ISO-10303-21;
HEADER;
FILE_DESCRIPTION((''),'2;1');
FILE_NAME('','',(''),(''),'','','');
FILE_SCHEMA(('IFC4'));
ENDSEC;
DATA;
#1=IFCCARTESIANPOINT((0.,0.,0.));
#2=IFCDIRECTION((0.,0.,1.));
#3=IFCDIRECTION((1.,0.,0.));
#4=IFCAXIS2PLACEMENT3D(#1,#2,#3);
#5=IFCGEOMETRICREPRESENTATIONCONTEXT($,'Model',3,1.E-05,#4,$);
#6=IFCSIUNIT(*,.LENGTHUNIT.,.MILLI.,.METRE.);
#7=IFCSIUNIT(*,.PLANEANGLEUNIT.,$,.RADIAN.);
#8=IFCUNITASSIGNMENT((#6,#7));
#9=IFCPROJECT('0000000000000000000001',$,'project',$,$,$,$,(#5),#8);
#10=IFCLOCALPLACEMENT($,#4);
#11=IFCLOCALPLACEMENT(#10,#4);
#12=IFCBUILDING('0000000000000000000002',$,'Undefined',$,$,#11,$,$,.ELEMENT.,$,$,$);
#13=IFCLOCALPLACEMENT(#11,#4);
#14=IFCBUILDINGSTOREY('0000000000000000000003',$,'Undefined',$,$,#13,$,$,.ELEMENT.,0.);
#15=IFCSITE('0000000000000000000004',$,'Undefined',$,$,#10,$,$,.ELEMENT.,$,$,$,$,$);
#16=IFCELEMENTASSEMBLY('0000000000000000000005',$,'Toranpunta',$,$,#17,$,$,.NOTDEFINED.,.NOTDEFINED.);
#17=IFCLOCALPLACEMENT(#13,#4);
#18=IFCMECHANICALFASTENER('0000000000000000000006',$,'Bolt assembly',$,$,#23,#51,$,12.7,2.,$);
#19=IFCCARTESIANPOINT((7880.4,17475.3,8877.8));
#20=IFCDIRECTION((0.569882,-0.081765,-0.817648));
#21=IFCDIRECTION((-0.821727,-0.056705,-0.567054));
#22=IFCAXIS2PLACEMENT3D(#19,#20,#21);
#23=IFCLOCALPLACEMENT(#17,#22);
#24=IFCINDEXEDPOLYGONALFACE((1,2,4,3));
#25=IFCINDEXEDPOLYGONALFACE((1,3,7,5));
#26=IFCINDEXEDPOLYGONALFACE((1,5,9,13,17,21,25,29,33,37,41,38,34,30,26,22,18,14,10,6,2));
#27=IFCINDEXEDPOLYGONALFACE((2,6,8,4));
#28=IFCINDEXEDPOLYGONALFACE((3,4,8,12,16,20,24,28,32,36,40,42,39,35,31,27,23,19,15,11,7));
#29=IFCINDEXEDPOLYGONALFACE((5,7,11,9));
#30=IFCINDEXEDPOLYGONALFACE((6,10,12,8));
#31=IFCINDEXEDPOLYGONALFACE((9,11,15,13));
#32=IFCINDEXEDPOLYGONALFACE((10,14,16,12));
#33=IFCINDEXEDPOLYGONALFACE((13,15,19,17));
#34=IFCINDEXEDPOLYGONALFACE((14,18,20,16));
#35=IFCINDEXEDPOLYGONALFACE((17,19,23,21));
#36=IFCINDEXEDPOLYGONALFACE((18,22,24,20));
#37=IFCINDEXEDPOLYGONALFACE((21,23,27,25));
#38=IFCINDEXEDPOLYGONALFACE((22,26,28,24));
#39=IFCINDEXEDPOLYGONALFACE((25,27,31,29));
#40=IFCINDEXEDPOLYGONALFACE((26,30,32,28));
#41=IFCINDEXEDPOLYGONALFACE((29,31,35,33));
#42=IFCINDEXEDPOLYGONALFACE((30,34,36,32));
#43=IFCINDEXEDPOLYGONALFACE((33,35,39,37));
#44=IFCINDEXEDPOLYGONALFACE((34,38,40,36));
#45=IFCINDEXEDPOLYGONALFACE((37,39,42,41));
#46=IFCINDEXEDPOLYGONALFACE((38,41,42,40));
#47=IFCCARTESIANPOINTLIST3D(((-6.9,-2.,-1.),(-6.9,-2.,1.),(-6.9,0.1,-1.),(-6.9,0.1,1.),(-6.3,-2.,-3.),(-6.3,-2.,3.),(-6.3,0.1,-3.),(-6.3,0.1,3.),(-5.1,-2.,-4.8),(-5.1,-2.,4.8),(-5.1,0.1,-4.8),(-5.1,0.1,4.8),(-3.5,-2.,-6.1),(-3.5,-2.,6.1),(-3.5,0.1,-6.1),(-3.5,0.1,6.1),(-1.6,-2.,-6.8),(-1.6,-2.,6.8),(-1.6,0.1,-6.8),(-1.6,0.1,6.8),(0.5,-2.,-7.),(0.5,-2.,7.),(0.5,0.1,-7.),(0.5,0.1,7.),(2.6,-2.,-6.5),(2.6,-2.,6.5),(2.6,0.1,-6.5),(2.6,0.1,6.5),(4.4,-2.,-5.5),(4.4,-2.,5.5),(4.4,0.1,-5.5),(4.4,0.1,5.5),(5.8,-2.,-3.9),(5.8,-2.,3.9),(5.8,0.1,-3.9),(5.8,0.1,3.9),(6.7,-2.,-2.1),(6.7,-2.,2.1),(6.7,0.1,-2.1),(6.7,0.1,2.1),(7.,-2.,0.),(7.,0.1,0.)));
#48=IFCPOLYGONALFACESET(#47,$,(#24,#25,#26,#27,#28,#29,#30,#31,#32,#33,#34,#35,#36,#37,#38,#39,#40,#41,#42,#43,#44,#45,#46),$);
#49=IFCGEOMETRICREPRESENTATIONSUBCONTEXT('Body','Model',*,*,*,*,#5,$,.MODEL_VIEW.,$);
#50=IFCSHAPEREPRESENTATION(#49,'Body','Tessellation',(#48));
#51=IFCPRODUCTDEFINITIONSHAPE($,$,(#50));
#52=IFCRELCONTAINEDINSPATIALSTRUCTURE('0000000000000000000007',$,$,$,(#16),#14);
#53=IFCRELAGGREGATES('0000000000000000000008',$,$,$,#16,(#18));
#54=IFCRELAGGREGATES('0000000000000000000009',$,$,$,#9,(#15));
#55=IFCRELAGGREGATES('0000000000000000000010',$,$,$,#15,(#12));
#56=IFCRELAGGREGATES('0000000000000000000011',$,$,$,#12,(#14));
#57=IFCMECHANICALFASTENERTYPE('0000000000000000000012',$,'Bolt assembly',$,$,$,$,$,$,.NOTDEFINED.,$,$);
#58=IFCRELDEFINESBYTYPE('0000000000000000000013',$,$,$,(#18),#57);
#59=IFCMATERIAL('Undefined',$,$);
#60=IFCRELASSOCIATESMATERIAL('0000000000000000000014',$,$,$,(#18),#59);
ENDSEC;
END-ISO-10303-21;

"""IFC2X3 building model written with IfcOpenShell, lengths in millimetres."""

from ifc_helpers import new_model, si_unit, frame, origin_with_axes, origin_2d_with_axis, place, context, subcontext, project, spatial, circle, extrude, source, transform, mapped, material, type_object, element, aggregate, save


model = new_model("IFC2X3")

# Units and contexts
model_context = context("Model", 3, precision=1e-05, world=origin_with_axes())
body_context = subcontext(model_context, "Body", "Model", "MODEL_VIEW")
ifc_project = project(units=[si_unit("LENGTHUNIT", "METRE", prefix="MILLI"), si_unit("PLANEANGLEUNIT", "RADIAN")], contexts=[model_context])

# Site, building, storey
site_placement = place(None, origin_with_axes())
site = spatial("IfcSite", under=ifc_project, at=site_placement, Name="Undefined", CompositionType="ELEMENT")
building_placement = place(site_placement, origin_with_axes())
building = spatial("IfcBuilding", under=site, at=building_placement, Name="Undefined", CompositionType="ELEMENT")
storey_placement = place(building_placement, origin_with_axes())
storey = spatial("IfcBuildingStorey", under=building, at=storey_placement, Name="Undefined", CompositionType="ELEMENT", Elevation=0.0)

# Element assembly, mechanical fastener
assembly_1_placement = place(storey_placement, origin_with_axes())
assembly_1 = element("IfcElementAssembly", 1, at=assembly_1_placement, inside=storey, Name="Toranpunta", AssemblyPlace="NOTDEFINED", PredefinedType="NOTDEFINED")
ifc_material_1 = material(Name="Undefined")
mechanical_fastener_type = type_object("IfcMechanicalFastenerType", Name="Bolt assembly")
shared_shape_1 = source(origin_with_axes(), body_context, "Body", "SweptSolid", [
    extrude(circle(Radius=7.0, at=origin_2d_with_axis()), frame((0.0, -2.0, 0.0), z_axis=(0.0, 1.0, 0.0), x_axis=(1.0, 0.0, 0.0)), (0.0, 0.0, 1.0), 2.1),
])
mechanical_fastener_1_placement = place(assembly_1_placement, frame((7880.4, 17475.3, 8877.8), z_axis=(0.569882, -0.081765, -0.817648), x_axis=(-0.821727, -0.056705, -0.567054)))
mechanical_fastener_1 = element("IfcMechanicalFastener", 2, at=mechanical_fastener_1_placement, type_object=mechanical_fastener_type, material=ifc_material_1, Name="Bolt assembly", NominalDiameter=12.7, NominalLength=2.0, context=body_context, shape_type="MappedRepresentation", body=[
    mapped(shared_shape_1, transform((0.0, 0.0, 0.0))),
])
aggregate(assembly_1, [mechanical_fastener_1])

save(model, "model.ifc")
